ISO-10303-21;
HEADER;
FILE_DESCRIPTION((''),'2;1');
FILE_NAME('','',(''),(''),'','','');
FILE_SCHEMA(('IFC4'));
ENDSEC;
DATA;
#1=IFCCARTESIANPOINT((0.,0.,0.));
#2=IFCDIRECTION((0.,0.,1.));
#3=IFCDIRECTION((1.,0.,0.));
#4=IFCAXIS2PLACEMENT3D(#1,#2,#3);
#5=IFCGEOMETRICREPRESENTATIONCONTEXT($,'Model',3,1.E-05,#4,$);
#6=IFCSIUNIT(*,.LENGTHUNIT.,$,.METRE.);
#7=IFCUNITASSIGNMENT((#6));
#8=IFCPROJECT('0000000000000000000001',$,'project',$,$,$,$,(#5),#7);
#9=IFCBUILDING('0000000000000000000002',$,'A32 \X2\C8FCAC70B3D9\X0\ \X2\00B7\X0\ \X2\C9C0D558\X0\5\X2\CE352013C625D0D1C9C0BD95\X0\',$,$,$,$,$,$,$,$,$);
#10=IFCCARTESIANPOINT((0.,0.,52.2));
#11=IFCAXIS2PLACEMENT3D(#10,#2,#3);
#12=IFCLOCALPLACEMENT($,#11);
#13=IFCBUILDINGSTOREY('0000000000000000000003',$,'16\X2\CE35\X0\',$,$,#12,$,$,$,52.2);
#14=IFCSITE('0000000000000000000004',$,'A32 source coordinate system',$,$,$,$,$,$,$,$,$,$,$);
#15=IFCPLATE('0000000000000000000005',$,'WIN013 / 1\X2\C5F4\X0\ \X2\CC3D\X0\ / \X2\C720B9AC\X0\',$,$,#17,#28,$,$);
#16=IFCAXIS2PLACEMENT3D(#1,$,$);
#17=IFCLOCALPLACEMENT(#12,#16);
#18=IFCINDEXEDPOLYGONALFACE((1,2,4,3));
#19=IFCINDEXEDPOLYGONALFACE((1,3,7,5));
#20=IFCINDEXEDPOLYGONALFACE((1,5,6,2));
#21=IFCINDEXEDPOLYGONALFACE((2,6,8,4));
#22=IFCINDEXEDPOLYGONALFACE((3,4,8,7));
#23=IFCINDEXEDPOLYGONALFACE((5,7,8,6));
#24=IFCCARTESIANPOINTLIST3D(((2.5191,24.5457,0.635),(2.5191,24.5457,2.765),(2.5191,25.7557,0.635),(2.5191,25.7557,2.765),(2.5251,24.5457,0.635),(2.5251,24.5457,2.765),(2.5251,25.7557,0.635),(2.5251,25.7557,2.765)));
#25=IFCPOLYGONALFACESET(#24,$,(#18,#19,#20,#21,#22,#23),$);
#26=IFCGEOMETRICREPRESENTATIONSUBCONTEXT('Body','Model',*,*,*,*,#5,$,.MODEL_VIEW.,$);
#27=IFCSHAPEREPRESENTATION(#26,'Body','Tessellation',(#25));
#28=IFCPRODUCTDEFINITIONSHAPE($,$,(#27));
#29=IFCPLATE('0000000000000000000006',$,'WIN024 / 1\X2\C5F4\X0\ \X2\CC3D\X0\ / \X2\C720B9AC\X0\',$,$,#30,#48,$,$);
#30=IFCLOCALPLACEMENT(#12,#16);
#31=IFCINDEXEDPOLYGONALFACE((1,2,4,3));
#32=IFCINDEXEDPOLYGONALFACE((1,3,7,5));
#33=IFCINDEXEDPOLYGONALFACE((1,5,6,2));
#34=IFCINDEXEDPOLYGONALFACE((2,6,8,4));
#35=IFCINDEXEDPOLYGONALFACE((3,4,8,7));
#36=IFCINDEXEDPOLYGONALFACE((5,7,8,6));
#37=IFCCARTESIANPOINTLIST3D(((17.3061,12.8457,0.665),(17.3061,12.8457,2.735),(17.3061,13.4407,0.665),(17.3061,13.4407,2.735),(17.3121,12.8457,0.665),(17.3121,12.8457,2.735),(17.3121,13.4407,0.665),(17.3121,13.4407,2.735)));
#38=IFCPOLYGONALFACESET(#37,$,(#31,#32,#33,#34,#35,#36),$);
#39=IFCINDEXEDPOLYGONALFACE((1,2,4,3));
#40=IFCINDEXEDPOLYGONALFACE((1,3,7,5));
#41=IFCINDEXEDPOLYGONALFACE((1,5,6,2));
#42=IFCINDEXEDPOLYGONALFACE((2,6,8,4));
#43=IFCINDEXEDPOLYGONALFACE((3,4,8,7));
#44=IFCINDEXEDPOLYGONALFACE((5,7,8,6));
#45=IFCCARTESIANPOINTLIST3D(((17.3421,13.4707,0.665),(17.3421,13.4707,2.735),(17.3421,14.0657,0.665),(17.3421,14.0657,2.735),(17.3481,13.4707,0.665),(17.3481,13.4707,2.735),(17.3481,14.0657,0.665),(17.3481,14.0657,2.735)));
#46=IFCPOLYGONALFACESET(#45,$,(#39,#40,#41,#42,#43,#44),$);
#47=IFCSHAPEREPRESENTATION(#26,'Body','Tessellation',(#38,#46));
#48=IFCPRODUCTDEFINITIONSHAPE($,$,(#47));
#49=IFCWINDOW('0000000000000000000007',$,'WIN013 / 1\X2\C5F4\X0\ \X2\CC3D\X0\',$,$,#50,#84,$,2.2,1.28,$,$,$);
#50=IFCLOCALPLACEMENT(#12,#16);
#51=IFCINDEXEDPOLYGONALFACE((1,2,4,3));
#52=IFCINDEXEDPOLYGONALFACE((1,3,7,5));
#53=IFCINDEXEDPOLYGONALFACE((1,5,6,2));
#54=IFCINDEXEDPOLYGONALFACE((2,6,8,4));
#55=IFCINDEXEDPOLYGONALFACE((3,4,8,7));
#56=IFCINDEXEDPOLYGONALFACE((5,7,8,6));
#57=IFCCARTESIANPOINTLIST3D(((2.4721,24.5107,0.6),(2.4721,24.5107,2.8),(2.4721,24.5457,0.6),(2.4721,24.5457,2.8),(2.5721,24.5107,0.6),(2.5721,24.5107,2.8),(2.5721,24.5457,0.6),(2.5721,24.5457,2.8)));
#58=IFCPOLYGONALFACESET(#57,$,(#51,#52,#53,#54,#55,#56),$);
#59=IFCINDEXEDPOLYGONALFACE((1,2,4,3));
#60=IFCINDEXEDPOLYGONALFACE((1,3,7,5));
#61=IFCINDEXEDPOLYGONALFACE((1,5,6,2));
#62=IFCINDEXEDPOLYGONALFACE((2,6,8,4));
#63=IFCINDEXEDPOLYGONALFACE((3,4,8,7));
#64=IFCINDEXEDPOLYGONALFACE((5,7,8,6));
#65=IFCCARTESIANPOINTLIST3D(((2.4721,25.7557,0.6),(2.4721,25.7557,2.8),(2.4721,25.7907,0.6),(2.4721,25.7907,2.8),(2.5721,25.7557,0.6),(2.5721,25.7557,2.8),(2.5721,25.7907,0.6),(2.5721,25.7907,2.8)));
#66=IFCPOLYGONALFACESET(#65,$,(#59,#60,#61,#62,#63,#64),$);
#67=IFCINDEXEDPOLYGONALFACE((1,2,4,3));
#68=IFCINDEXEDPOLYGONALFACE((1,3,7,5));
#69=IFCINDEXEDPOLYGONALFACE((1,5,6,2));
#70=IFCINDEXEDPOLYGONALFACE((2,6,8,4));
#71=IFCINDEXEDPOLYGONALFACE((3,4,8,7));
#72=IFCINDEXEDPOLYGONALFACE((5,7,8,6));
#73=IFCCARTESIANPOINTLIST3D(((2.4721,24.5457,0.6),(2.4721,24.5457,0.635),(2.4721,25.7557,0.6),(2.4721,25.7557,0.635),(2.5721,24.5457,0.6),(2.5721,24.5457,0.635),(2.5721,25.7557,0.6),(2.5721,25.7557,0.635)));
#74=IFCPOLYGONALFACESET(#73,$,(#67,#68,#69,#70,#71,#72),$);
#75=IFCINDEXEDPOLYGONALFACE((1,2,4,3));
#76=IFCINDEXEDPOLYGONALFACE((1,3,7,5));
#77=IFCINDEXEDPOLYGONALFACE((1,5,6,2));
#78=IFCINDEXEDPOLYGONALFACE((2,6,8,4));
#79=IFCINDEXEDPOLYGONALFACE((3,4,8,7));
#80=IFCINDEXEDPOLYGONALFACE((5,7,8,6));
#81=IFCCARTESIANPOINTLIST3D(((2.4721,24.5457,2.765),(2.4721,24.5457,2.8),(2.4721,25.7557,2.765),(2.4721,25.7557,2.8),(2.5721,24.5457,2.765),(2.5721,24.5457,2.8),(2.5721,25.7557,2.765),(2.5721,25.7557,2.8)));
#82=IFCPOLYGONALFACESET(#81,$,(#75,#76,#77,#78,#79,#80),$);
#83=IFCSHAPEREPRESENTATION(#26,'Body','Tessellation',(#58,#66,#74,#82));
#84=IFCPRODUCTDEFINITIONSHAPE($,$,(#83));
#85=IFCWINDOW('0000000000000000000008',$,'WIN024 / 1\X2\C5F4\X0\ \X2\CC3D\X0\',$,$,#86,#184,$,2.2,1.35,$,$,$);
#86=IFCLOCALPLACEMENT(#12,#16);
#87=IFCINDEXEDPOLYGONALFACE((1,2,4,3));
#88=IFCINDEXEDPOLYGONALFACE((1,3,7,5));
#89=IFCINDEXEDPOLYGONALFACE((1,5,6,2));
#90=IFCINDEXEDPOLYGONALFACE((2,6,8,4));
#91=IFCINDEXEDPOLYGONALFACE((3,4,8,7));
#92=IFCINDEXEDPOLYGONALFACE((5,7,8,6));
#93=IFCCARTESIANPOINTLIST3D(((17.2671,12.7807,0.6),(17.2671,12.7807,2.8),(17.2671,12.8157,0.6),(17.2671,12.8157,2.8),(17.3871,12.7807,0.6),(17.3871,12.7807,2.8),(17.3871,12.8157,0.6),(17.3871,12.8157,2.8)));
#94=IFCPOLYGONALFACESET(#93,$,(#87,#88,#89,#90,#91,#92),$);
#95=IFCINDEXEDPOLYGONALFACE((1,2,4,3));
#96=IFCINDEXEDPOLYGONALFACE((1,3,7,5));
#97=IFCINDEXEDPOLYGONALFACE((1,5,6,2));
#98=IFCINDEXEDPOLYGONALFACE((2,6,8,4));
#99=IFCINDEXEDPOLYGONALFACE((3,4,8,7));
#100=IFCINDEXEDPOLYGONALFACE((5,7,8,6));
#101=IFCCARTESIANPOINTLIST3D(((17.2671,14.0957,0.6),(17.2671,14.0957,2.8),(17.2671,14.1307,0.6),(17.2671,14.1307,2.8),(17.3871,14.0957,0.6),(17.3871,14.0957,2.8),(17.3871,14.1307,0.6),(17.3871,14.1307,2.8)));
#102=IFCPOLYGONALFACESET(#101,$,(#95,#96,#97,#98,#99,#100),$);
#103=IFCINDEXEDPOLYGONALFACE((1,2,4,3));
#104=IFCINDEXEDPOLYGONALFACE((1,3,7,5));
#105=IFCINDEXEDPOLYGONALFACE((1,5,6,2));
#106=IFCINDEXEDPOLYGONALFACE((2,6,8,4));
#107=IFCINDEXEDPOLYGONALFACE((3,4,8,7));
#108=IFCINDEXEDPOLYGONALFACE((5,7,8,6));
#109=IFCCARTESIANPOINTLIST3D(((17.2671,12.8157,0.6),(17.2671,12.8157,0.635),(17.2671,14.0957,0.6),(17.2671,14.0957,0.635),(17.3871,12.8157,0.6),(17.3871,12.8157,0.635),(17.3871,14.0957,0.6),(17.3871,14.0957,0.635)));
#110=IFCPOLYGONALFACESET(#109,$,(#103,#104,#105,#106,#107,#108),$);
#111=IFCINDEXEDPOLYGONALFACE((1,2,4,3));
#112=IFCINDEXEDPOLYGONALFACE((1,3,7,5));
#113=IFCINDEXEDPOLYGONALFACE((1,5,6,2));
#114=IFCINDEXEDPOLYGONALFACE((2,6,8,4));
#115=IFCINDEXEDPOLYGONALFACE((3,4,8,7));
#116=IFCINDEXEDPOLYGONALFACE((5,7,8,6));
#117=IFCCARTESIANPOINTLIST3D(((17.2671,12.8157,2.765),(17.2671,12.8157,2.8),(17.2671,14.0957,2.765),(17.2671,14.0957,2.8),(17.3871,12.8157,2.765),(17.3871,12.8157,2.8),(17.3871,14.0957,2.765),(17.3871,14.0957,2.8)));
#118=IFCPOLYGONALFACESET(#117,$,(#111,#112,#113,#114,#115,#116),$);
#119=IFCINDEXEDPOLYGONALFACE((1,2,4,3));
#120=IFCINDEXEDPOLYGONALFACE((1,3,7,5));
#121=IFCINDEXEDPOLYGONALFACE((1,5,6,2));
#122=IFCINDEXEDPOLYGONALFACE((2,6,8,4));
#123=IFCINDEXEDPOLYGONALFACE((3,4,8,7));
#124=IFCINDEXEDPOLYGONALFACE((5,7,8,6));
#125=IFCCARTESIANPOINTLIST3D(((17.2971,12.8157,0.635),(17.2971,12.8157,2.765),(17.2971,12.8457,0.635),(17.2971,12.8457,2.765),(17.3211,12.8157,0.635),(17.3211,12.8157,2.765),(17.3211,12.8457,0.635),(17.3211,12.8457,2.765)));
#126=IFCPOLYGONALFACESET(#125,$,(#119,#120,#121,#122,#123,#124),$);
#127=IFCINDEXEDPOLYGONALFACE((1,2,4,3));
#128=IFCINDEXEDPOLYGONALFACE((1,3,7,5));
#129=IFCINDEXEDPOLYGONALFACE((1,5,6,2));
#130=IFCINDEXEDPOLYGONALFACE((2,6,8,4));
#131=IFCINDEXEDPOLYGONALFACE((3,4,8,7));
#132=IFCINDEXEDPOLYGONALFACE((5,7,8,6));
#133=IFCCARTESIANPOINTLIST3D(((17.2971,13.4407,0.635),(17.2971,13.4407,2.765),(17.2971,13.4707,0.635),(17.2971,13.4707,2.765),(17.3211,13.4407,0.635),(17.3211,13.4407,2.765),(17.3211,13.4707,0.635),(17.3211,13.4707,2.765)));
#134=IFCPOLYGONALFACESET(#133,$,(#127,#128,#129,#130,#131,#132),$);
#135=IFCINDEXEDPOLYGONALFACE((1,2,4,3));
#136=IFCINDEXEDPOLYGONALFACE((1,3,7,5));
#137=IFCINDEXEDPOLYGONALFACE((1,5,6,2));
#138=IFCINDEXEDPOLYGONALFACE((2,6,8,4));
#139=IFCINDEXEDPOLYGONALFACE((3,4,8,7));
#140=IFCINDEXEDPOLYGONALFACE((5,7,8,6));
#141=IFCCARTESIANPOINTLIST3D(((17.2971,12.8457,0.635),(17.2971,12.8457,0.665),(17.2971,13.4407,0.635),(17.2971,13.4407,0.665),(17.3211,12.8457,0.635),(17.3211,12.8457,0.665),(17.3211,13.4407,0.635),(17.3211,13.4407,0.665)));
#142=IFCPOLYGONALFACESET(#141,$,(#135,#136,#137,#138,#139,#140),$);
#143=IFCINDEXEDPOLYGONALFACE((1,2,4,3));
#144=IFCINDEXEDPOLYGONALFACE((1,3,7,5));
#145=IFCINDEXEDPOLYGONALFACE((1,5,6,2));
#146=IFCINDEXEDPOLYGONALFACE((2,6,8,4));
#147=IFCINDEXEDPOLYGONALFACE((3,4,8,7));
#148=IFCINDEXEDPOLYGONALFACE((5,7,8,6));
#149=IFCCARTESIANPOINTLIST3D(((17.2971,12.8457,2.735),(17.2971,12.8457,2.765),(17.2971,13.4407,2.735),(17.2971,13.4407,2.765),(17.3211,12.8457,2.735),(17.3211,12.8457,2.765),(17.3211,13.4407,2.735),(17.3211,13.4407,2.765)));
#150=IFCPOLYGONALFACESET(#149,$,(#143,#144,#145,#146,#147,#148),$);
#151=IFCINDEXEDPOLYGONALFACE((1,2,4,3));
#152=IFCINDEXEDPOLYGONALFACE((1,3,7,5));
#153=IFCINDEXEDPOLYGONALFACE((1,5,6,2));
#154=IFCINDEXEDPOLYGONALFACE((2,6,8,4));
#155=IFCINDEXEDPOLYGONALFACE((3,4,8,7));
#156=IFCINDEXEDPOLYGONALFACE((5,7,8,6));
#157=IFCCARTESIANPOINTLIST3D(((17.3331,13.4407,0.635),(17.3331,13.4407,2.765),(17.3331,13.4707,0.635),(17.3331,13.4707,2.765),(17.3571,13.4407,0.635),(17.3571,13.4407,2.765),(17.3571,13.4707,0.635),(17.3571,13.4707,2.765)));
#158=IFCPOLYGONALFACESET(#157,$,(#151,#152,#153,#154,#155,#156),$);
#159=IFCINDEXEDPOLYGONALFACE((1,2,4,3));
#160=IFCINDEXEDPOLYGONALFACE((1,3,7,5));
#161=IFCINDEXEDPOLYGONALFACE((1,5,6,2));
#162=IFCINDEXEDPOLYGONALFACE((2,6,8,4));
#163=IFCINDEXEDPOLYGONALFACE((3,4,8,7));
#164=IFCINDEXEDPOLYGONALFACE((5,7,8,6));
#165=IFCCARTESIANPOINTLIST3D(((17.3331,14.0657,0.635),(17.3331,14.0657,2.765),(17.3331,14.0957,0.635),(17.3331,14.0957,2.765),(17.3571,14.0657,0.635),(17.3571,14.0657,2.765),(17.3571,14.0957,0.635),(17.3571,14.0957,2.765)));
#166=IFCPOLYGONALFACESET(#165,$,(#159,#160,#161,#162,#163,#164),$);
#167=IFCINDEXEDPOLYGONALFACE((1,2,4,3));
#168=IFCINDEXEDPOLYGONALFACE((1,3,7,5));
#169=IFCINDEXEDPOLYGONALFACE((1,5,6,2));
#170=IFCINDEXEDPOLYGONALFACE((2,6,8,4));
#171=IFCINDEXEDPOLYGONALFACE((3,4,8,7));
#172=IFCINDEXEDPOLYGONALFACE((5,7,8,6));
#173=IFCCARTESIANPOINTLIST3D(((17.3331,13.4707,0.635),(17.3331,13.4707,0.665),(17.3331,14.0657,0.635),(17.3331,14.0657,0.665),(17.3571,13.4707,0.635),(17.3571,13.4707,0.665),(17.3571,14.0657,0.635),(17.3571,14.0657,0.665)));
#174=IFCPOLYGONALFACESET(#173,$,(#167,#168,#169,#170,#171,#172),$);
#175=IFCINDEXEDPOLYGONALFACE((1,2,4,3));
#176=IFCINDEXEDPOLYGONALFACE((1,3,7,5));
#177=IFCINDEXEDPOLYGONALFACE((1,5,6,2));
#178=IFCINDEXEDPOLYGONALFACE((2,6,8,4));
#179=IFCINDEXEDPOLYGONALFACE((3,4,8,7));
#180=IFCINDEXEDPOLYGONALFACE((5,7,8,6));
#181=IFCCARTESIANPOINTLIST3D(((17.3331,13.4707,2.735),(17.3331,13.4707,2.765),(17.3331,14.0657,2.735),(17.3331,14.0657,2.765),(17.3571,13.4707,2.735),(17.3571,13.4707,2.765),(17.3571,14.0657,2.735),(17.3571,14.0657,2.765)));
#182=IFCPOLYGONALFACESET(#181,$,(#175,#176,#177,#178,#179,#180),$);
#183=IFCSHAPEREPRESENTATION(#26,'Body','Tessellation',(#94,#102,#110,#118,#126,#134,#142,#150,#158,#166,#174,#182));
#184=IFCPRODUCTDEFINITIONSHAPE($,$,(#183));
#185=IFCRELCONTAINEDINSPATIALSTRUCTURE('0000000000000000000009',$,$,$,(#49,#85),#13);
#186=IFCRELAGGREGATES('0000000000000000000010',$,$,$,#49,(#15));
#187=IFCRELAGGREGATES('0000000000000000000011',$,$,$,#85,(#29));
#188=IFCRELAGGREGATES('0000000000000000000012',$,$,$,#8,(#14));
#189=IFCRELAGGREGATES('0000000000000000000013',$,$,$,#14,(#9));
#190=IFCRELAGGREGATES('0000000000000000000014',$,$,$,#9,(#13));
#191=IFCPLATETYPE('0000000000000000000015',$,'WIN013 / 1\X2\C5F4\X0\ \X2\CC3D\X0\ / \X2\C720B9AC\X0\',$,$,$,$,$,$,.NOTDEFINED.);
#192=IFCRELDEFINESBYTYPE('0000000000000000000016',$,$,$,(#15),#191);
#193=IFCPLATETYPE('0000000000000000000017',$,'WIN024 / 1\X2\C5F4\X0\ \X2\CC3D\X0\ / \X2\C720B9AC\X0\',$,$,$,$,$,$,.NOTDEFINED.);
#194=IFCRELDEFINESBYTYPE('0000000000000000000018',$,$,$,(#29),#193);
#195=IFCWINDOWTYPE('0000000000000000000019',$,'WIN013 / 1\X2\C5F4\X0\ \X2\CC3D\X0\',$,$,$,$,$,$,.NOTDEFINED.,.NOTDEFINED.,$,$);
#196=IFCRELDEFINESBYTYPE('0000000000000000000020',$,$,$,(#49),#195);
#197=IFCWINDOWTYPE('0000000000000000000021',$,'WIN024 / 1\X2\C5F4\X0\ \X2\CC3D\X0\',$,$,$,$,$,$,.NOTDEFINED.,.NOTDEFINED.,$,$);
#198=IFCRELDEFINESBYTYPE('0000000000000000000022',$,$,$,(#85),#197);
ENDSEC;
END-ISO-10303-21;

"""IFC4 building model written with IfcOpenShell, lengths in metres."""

from ifc_helpers import new_model, si_unit, frame, origin, origin_with_axes, place, context, subcontext, project, spatial, polyline, outline, extrude, source, transform, mapped, type_object, type_shapes, element, aggregate, save


model = new_model("IFC4")

# Units and contexts
model_context = context("Model", 3, precision=1e-05, world=origin_with_axes())
body_context = subcontext(model_context, "Body", "Model", "MODEL_VIEW")
ifc_project = project(units=[si_unit("LENGTHUNIT", "METRE")], contexts=[model_context])

# Plates
plate_type_1 = type_object("IfcPlateType", Name="WIN013 / 1열 창 / 유리", PredefinedType="NOTDEFINED")
shared_shape_1 = source(origin(), body_context, "Body", "SweptSolid", [
    extrude(outline(polyline([(2.5191, 24.5457), (2.5191, 25.7557), (2.5251, 25.7557), (2.5251, 24.5457), (2.5191, 24.5457)])), frame((0.0, 0.0, 0.635)), (0.0, 0.0, 1.0), 2.13),
])
type_shapes(plate_type_1, [shared_shape_1])
storey_placement = place(None, frame((0.0, 0.0, 52.2), z_axis=(0.0, 0.0, 1.0), x_axis=(1.0, 0.0, 0.0)))
window_1_placement = place(storey_placement, origin_with_axes())
plate_1_placement = place(window_1_placement, origin_with_axes())
plate_1 = element("IfcPlate", 1, at=plate_1_placement, type_object=plate_type_1, Name="WIN013 / 1열 창 / 유리", context=body_context, shape_type="MappedRepresentation", body=[
    mapped(shared_shape_1, transform((0.0, 0.0, 0.0), scale=1.0)),
])
plate_type_2 = type_object("IfcPlateType", Name="WIN024 / 1열 창 / 유리", PredefinedType="NOTDEFINED")
shared_shape_2 = source(origin(), body_context, "Body", "SweptSolid", [
    extrude(outline(polyline([(17.3061, 12.8457), (17.3061, 13.4407), (17.3121, 13.4407), (17.3121, 12.8457), (17.3061, 12.8457)])), frame((0.0, 0.0, 0.665)), (0.0, 0.0, 1.0), 2.07),
    extrude(outline(polyline([(17.3421, 13.4707), (17.3421, 14.0657), (17.3481, 14.0657), (17.3481, 13.4707), (17.3421, 13.4707)])), frame((0.0, 0.0, 0.665)), (0.0, 0.0, 1.0), 2.07),
])
type_shapes(plate_type_2, [shared_shape_2])
window_2_placement = place(storey_placement, origin_with_axes())
plate_2_placement = place(window_2_placement, origin_with_axes())
plate_2 = element("IfcPlate", 2, at=plate_2_placement, type_object=plate_type_2, Name="WIN024 / 1열 창 / 유리", context=body_context, shape_type="MappedRepresentation", body=[
    mapped(shared_shape_2, transform((0.0, 0.0, 0.0), scale=1.0)),
])

# Site, building, storey
site = spatial("IfcSite", under=ifc_project, Name="A32 source coordinate system")
building = spatial("IfcBuilding", under=site, Name="A32 주거동 · 지하5층–옥탑지붕")
storey = spatial("IfcBuildingStorey", under=building, at=storey_placement, Name="16층", Elevation=52.2)

# Windows
window_type_1 = type_object("IfcWindowType", Name="WIN013 / 1열 창", PartitioningType="NOTDEFINED", PredefinedType="NOTDEFINED")
shared_shape_3 = source(origin(), body_context, "Body", "SweptSolid", [
    extrude(outline(polyline([(2.4721, 24.5107), (2.4721, 24.5457), (2.5721, 24.5457), (2.5721, 24.5107), (2.4721, 24.5107)])), frame((0.0, 0.0, 0.6)), (0.0, 0.0, 1.0), 2.2),
    extrude(outline(polyline([(2.4721, 25.7557), (2.4721, 25.7907), (2.5721, 25.7907), (2.5721, 25.7557), (2.4721, 25.7557)])), frame((0.0, 0.0, 0.6)), (0.0, 0.0, 1.0), 2.2),
    extrude(outline(polyline([(2.4721, 24.5457), (2.4721, 25.7557), (2.5721, 25.7557), (2.5721, 24.5457), (2.4721, 24.5457)])), frame((0.0, 0.0, 0.6)), (0.0, 0.0, 1.0), 0.035),
    extrude(outline(polyline([(2.4721, 24.5457), (2.4721, 25.7557), (2.5721, 25.7557), (2.5721, 24.5457), (2.4721, 24.5457)])), frame((0.0, 0.0, 2.765)), (0.0, 0.0, 1.0), 0.035),
])
type_shapes(window_type_1, [shared_shape_3])
window_1 = element("IfcWindow", 3, at=window_1_placement, inside=storey, type_object=window_type_1, Name="WIN013 / 1열 창", OverallHeight=2.2, OverallWidth=1.28, context=body_context, shape_type="MappedRepresentation", body=[
    mapped(shared_shape_3, transform((0.0, 0.0, 0.0), scale=1.0)),
])
aggregate(window_1, [plate_1])
window_type_2 = type_object("IfcWindowType", Name="WIN024 / 1열 창", PartitioningType="NOTDEFINED", PredefinedType="NOTDEFINED")
shared_shape_4 = source(origin(), body_context, "Body", "SweptSolid", [
    extrude(outline(polyline([(17.2671, 12.7807), (17.2671, 12.8157), (17.3871, 12.8157), (17.3871, 12.7807), (17.2671, 12.7807)])), frame((0.0, 0.0, 0.6)), (0.0, 0.0, 1.0), 2.2),
    extrude(outline(polyline([(17.2671, 14.0957), (17.2671, 14.1307), (17.3871, 14.1307), (17.3871, 14.0957), (17.2671, 14.0957)])), frame((0.0, 0.0, 0.6)), (0.0, 0.0, 1.0), 2.2),
    extrude(outline(polyline([(17.2671, 12.8157), (17.2671, 14.0957), (17.3871, 14.0957), (17.3871, 12.8157), (17.2671, 12.8157)])), frame((0.0, 0.0, 0.6)), (0.0, 0.0, 1.0), 0.035),
    extrude(outline(polyline([(17.2671, 12.8157), (17.2671, 14.0957), (17.3871, 14.0957), (17.3871, 12.8157), (17.2671, 12.8157)])), frame((0.0, 0.0, 2.765)), (0.0, 0.0, 1.0), 0.035),
    extrude(outline(polyline([(17.2971, 12.8157), (17.2971, 12.8457), (17.3211, 12.8457), (17.3211, 12.8157), (17.2971, 12.8157)])), frame((0.0, 0.0, 0.635)), (0.0, 0.0, 1.0), 2.13),
    extrude(outline(polyline([(17.2971, 13.4407), (17.2971, 13.4707), (17.3211, 13.4707), (17.3211, 13.4407), (17.2971, 13.4407)])), frame((0.0, 0.0, 0.635)), (0.0, 0.0, 1.0), 2.13),
    extrude(outline(polyline([(17.2971, 12.8457), (17.2971, 13.4407), (17.3211, 13.4407), (17.3211, 12.8457), (17.2971, 12.8457)])), frame((0.0, 0.0, 0.635)), (0.0, 0.0, 1.0), 0.03),
    extrude(outline(polyline([(17.2971, 12.8457), (17.2971, 13.4407), (17.3211, 13.4407), (17.3211, 12.8457), (17.2971, 12.8457)])), frame((0.0, 0.0, 2.735)), (0.0, 0.0, 1.0), 0.03),
    extrude(outline(polyline([(17.3331, 13.4407), (17.3331, 13.4707), (17.3571, 13.4707), (17.3571, 13.4407), (17.3331, 13.4407)])), frame((0.0, 0.0, 0.635)), (0.0, 0.0, 1.0), 2.13),
    extrude(outline(polyline([(17.3331, 14.0657), (17.3331, 14.0957), (17.3571, 14.0957), (17.3571, 14.0657), (17.3331, 14.0657)])), frame((0.0, 0.0, 0.635)), (0.0, 0.0, 1.0), 2.13),
    extrude(outline(polyline([(17.3331, 13.4707), (17.3331, 14.0657), (17.3571, 14.0657), (17.3571, 13.4707), (17.3331, 13.4707)])), frame((0.0, 0.0, 0.635)), (0.0, 0.0, 1.0), 0.03),
    extrude(outline(polyline([(17.3331, 13.4707), (17.3331, 14.0657), (17.3571, 14.0657), (17.3571, 13.4707), (17.3331, 13.4707)])), frame((0.0, 0.0, 2.735)), (0.0, 0.0, 1.0), 0.03),
])
type_shapes(window_type_2, [shared_shape_4])
window_2 = element("IfcWindow", 4, at=window_2_placement, inside=storey, type_object=window_type_2, Name="WIN024 / 1열 창", OverallHeight=2.2, OverallWidth=1.35, context=body_context, shape_type="MappedRepresentation", body=[
    mapped(shared_shape_4, transform((0.0, 0.0, 0.0), scale=1.0)),
])
aggregate(window_2, [plate_2])

save(model, "model.ifc")
